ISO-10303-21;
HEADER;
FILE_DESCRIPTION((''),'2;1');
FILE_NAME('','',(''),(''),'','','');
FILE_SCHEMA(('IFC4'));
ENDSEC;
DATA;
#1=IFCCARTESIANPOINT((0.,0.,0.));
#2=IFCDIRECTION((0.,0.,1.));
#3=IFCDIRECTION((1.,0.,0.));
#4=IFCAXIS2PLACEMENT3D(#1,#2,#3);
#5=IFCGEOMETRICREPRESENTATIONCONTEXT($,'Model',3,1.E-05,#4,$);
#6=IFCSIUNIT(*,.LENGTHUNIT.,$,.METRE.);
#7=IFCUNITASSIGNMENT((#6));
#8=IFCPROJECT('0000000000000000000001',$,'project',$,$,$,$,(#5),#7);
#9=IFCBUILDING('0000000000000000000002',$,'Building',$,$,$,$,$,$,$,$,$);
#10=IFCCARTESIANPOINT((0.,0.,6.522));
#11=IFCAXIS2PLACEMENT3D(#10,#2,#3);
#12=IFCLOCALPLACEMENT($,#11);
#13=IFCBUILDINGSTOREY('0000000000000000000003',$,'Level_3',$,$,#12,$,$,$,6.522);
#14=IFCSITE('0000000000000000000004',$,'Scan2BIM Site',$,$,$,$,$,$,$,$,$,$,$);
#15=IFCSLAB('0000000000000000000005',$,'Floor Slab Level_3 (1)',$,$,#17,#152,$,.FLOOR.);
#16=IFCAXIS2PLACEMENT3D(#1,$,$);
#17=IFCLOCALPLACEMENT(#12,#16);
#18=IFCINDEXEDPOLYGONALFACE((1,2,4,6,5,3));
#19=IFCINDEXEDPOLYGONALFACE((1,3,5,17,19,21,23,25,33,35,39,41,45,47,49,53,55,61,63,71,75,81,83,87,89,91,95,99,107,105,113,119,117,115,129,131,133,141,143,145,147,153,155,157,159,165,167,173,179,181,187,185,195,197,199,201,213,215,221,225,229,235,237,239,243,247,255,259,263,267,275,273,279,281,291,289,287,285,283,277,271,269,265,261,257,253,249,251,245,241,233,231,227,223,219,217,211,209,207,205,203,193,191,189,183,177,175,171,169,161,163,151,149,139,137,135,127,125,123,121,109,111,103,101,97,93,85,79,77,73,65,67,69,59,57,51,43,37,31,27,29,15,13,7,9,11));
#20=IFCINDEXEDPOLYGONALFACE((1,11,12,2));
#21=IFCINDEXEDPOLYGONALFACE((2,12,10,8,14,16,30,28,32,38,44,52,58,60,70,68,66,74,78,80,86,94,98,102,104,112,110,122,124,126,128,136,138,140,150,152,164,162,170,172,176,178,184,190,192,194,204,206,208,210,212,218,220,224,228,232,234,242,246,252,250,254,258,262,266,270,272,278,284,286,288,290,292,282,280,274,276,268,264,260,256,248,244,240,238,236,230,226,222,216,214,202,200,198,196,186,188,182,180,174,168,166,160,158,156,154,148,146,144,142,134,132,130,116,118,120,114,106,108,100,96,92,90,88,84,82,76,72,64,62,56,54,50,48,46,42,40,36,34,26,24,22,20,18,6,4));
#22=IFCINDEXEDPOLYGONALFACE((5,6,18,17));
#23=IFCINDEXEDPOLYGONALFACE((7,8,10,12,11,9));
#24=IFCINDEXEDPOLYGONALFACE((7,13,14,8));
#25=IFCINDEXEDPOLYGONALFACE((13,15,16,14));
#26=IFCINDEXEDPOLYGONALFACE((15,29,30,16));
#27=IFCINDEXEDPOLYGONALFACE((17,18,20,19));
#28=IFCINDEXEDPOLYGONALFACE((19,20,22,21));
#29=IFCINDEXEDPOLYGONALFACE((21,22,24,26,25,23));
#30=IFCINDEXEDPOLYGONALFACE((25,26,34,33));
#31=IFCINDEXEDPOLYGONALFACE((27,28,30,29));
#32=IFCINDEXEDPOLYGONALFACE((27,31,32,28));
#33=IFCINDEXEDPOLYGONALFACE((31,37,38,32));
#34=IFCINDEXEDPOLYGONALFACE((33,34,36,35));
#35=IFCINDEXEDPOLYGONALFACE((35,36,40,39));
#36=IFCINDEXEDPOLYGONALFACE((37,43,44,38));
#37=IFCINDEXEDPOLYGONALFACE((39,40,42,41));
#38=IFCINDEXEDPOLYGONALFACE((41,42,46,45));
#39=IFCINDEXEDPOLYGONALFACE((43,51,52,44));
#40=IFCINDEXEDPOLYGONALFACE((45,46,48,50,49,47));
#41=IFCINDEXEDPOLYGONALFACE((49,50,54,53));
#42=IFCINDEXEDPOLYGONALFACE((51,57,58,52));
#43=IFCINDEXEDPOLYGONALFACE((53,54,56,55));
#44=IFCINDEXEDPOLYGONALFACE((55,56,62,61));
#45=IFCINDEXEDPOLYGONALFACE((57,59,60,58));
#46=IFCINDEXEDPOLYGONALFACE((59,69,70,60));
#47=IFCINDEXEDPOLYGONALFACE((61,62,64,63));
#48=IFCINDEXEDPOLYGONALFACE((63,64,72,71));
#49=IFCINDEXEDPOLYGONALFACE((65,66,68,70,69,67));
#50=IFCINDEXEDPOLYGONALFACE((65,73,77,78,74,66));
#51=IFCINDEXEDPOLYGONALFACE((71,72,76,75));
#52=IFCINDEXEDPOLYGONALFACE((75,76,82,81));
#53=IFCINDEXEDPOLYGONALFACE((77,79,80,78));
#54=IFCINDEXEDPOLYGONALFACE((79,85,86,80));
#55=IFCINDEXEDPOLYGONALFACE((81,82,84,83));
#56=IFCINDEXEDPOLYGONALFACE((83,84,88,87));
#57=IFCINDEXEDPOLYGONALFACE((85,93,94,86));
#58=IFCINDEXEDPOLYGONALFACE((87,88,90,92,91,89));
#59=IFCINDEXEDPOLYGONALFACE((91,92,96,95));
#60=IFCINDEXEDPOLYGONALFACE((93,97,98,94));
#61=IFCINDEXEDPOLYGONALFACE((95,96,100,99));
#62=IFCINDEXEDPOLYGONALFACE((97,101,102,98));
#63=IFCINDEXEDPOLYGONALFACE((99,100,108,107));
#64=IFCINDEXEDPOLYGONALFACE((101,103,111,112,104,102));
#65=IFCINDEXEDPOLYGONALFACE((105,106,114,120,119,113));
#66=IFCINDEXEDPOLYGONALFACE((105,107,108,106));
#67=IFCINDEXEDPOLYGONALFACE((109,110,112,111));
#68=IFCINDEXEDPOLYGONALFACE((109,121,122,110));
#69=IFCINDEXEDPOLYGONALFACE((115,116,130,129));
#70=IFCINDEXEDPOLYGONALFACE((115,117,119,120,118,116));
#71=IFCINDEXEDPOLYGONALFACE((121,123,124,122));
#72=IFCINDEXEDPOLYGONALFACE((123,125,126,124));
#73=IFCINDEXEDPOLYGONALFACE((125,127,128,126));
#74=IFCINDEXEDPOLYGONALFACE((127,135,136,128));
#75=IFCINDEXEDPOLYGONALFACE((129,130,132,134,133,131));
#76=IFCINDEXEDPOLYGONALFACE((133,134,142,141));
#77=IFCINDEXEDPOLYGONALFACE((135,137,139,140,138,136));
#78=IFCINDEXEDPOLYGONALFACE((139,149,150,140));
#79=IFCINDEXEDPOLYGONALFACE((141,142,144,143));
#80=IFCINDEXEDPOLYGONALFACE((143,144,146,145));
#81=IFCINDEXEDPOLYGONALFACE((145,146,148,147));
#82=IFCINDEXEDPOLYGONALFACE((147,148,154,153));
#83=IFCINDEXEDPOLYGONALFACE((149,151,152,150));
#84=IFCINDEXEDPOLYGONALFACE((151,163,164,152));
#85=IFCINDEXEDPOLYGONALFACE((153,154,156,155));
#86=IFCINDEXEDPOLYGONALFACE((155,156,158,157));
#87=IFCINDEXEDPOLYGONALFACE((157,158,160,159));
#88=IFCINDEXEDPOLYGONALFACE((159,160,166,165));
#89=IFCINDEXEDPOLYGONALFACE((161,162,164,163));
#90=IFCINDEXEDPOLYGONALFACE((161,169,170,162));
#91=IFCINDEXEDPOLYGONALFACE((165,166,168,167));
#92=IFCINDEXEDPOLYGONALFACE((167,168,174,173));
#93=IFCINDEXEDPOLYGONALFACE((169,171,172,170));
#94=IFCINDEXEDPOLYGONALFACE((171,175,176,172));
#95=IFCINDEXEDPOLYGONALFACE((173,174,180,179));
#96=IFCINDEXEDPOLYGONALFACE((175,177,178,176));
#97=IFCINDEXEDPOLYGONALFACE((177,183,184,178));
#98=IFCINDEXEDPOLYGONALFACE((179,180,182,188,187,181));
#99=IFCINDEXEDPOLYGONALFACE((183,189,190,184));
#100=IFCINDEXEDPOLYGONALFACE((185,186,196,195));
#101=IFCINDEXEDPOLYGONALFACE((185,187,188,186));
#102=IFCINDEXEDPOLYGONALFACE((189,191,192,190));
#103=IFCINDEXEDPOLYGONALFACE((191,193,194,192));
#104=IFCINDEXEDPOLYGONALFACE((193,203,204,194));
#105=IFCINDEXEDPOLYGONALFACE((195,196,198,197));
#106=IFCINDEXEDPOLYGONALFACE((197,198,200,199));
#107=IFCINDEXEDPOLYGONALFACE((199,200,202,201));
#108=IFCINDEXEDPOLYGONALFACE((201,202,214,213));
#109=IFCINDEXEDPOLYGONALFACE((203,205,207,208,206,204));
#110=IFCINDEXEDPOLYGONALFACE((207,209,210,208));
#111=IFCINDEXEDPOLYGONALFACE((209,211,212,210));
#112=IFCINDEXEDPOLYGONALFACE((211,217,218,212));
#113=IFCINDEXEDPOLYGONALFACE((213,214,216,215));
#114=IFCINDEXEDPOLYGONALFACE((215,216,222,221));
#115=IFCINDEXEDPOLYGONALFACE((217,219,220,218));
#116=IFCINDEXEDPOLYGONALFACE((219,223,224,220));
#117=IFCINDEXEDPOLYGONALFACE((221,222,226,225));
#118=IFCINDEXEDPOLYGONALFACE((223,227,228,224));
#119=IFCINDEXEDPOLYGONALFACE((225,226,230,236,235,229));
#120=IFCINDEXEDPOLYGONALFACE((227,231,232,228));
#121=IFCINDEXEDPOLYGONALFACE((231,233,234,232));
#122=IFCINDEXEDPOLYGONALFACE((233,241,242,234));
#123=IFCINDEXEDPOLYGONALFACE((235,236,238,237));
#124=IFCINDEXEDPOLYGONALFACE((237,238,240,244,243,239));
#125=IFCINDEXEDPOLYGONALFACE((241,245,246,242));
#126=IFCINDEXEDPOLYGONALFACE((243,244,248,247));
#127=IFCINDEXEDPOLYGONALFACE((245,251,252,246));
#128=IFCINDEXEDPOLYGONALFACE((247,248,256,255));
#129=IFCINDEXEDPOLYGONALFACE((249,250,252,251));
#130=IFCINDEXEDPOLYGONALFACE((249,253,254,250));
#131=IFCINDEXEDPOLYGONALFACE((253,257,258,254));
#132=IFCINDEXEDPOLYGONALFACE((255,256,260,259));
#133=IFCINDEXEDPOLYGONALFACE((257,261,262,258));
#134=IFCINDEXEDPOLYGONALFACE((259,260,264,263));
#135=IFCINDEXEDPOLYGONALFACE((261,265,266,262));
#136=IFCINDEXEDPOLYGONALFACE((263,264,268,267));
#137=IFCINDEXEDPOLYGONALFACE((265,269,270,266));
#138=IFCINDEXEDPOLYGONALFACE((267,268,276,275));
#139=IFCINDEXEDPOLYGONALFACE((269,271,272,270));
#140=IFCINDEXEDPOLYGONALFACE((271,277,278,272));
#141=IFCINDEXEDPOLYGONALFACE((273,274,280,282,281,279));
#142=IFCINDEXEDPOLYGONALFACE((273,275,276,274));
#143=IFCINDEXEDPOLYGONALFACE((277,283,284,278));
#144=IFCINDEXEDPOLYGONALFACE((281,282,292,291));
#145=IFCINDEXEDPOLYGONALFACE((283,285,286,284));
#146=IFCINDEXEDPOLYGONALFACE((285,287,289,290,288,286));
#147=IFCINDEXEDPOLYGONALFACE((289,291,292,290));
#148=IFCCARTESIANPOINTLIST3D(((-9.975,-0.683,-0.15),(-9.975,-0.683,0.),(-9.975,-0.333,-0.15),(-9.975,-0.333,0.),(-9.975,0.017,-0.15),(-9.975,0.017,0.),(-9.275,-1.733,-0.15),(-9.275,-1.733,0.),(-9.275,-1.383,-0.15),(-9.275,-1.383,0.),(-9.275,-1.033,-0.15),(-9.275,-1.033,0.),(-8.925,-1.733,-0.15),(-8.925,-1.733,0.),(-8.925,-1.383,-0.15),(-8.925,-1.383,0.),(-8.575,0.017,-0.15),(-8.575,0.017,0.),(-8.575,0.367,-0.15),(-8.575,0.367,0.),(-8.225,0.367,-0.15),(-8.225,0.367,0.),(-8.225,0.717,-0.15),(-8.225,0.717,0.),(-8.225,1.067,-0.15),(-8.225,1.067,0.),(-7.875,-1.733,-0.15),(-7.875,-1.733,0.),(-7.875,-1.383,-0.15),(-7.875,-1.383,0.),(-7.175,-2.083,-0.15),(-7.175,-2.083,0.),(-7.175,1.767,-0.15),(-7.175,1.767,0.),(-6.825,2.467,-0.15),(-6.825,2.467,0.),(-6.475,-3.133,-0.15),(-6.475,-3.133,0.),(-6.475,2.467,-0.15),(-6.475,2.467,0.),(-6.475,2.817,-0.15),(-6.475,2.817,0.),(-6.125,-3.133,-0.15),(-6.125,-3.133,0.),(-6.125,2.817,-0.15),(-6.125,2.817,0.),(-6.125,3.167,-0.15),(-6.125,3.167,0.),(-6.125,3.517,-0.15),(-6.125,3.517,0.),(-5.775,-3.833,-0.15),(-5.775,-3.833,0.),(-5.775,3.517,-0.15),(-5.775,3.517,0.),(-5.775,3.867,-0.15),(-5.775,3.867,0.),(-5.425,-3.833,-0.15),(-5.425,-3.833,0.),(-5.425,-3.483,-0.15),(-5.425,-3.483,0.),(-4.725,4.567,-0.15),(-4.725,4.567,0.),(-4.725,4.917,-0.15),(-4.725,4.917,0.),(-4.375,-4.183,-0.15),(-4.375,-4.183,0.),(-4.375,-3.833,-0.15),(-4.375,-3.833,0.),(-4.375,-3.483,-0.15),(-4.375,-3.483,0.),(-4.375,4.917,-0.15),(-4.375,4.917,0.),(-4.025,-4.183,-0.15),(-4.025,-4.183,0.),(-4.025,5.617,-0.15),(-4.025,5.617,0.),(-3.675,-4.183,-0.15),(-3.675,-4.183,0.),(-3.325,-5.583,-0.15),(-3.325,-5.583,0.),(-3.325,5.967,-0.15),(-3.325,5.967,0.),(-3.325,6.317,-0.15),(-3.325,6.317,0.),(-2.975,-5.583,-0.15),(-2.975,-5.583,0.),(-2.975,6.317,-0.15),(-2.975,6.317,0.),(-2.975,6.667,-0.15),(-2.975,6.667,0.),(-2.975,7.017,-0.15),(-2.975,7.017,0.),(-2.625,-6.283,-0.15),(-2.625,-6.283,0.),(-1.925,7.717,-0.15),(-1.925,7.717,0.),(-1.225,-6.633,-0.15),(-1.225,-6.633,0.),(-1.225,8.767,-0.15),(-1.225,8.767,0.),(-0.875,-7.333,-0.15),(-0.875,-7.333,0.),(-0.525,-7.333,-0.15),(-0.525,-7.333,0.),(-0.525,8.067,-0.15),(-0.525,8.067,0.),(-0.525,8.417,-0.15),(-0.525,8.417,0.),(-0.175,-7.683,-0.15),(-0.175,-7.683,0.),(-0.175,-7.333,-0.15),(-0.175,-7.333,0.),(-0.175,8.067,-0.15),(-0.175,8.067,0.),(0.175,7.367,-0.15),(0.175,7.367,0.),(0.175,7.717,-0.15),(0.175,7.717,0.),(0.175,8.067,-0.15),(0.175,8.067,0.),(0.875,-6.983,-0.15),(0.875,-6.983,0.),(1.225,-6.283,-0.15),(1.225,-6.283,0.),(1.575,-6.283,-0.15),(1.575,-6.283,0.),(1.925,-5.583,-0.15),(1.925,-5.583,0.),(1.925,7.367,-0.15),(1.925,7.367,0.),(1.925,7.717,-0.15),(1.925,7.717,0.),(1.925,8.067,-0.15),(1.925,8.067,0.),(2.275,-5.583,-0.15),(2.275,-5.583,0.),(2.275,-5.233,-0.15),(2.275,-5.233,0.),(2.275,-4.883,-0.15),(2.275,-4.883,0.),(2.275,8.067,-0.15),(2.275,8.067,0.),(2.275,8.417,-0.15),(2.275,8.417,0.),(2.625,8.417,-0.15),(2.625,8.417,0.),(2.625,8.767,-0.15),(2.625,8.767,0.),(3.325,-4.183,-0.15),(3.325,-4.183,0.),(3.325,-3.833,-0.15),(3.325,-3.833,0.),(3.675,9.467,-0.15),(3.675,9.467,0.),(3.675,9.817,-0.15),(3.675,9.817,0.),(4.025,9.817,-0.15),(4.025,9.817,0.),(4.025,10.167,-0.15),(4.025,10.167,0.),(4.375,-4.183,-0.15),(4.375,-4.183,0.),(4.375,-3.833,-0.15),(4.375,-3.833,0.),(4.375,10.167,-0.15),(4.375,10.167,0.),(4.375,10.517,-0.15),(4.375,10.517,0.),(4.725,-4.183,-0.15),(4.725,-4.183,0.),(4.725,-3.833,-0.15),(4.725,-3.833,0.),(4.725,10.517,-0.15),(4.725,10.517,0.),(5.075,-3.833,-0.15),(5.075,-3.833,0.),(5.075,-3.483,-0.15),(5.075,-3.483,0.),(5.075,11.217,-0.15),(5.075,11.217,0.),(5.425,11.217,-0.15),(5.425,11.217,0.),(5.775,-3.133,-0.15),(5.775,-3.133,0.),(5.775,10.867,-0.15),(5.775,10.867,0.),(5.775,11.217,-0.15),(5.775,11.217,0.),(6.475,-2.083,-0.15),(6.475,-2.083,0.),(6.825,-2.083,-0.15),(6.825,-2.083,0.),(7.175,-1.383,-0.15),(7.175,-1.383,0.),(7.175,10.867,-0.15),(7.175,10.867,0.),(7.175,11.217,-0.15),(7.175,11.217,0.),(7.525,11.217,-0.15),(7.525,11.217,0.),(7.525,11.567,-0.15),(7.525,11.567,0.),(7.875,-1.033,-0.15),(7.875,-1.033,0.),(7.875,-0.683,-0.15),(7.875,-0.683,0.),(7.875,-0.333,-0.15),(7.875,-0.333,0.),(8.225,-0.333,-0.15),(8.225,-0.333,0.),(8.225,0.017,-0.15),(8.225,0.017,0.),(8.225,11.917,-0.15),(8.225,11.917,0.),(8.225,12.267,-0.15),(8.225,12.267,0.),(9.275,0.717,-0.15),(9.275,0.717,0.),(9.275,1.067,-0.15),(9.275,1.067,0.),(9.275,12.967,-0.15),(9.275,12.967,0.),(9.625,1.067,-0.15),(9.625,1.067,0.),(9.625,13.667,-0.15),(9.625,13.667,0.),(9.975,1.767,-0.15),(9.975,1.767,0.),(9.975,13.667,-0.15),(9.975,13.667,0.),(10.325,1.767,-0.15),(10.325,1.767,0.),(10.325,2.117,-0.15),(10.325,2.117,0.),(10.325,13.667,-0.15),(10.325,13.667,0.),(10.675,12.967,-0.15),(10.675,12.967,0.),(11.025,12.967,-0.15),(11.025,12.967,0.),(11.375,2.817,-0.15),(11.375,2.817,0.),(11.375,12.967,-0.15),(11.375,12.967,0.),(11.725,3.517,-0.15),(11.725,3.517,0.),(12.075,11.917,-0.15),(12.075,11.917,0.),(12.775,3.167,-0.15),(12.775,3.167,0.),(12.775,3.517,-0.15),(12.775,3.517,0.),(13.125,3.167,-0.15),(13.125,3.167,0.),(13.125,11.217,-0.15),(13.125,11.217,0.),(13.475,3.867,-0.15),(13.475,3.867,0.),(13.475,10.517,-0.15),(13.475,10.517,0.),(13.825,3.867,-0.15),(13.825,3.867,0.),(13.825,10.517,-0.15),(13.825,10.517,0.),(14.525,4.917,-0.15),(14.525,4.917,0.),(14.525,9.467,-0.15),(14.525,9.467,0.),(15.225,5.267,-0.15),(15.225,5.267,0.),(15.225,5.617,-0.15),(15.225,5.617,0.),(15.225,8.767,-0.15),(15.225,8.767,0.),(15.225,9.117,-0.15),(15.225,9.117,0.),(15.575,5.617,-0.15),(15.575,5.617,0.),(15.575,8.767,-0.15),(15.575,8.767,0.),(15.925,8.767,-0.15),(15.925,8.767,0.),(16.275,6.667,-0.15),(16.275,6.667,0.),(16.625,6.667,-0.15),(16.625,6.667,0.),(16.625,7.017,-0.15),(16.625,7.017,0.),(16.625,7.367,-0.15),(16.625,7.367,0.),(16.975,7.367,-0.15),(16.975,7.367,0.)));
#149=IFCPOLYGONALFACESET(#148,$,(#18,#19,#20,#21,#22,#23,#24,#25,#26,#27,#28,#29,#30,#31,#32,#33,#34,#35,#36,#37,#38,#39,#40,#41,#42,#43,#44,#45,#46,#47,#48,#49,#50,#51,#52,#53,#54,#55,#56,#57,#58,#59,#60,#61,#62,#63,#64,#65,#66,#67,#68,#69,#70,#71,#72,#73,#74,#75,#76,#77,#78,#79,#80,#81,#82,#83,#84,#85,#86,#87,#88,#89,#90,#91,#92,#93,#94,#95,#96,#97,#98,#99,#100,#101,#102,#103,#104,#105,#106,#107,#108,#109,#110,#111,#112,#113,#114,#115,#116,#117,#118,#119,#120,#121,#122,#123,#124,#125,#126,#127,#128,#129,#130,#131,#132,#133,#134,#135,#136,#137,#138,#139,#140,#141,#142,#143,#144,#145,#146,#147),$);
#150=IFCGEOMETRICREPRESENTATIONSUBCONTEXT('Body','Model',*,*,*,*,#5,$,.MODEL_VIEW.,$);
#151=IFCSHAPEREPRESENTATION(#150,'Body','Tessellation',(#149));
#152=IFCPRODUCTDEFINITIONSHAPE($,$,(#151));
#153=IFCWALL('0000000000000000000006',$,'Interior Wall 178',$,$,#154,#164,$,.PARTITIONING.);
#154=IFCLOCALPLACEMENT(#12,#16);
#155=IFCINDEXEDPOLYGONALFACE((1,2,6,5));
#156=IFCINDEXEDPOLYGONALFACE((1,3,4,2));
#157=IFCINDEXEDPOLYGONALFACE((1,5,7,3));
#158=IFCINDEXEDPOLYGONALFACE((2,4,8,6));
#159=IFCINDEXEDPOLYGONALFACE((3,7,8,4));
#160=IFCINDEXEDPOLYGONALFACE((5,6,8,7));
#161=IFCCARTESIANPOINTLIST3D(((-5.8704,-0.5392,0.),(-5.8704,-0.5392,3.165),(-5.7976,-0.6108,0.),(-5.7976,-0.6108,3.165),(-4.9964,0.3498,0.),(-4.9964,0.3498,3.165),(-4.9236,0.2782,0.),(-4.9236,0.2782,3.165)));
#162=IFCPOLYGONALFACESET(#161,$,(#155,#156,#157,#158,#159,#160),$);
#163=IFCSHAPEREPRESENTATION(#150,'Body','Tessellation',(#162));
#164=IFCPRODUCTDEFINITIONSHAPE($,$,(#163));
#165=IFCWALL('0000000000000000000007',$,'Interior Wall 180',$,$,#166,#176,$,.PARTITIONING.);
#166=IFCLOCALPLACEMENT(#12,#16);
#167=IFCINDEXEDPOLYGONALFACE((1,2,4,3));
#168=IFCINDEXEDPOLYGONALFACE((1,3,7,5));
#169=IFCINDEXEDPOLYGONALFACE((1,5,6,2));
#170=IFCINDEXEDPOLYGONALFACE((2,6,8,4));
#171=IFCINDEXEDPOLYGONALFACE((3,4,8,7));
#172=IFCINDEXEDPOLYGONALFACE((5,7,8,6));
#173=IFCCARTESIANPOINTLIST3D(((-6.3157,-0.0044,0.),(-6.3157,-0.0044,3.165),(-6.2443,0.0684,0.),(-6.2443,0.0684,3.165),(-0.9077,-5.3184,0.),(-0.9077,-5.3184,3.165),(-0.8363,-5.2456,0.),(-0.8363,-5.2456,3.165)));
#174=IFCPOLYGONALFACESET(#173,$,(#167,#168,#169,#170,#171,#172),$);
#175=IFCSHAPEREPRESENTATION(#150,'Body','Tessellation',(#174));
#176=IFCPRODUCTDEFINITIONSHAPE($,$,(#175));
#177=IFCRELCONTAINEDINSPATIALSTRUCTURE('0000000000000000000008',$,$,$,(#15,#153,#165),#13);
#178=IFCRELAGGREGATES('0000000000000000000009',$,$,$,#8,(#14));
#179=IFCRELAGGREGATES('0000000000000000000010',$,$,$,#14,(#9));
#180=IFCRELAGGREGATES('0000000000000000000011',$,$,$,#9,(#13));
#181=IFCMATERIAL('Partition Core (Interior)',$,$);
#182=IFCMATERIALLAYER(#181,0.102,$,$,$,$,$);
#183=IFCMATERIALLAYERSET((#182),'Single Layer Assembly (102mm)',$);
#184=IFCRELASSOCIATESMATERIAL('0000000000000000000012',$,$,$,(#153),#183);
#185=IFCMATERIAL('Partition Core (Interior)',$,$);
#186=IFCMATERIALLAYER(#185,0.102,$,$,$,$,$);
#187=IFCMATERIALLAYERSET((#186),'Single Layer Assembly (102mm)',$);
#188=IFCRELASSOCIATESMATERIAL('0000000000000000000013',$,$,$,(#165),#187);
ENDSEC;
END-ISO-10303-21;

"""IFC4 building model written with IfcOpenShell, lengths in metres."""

from ifc_helpers import new_model, si_unit, frame, origin, origin_with_axes, place, context, subcontext, project, spatial, polyline, rectangle, outline, extrude, material, layer, layer_set, element, save


model = new_model("IFC4")

# Units and contexts
model_context = context("Model", 3, precision=1e-05, world=origin_with_axes())
body_context = subcontext(model_context, "Body", "Model", "MODEL_VIEW")
ifc_project = project(units=[si_unit("LENGTHUNIT", "METRE")], contexts=[model_context])

# Site, building, storey
site = spatial("IfcSite", under=ifc_project, Name="Scan2BIM Site")
building = spatial("IfcBuilding", under=site, Name="Building")
storey_placement = place(None, frame((0.0, 0.0, 6.522), z_axis=(0.0, 0.0, 1.0), x_axis=(1.0, 0.0, 0.0)))
storey = spatial("IfcBuildingStorey", under=building, at=storey_placement, Name="Level_3", Elevation=6.522)

# Slab
slab_placement = place(storey_placement, frame((0.0, 0.0, -0.15), z_axis=(0.0, 0.0, 1.0), x_axis=(1.0, 0.0, 0.0)))
element("IfcSlab", 1, at=slab_placement, inside=storey, Name="Floor Slab Level_3 (1)", PredefinedType="FLOOR", context=body_context, shape_type="SweptSolid", body=[
    extrude(outline(polyline([(-0.175, -7.683), (0.875, -6.983), (1.225, -6.283), (1.575, -6.283), (1.925, -5.583), (2.275, -5.583), (2.275, -5.233), (2.275, -4.883), (3.325, -4.183), (3.325, -3.833), (4.375, -3.833), (4.375, -4.183), (4.725, -4.183), (4.725, -3.833), (5.075, -3.833), (5.075, -3.483), (5.775, -3.133), (6.475, -2.083), (6.825, -2.083), (7.175, -1.383), (7.875, -1.033), (7.875, -0.683), (7.875, -0.333), (8.225, -0.333), (8.225, 0.017), (9.275, 0.717), (9.275, 1.067), (9.625, 1.067), (9.975, 1.767), (10.325, 1.767), (10.325, 2.117), (11.375, 2.817), (11.725, 3.517), (12.775, 3.517), (12.775, 3.167), (13.125, 3.167), (13.475, 3.867), (13.825, 3.867), (14.525, 4.917), (15.225, 5.267), (15.225, 5.617), (15.575, 5.617), (16.275, 6.667), (16.625, 6.667), (16.625, 7.017), (16.625, 7.367), (16.975, 7.367), (15.925, 8.767), (15.575, 8.767), (15.225, 8.767), (15.225, 9.117), (14.525, 9.467), (13.825, 10.517), (13.475, 10.517), (13.125, 11.217), (12.075, 11.917), (11.375, 12.967), (11.025, 12.967), (10.675, 12.967), (10.325, 13.667), (9.975, 13.667), (9.625, 13.667), (9.275, 12.967), (8.225, 12.267), (8.225, 11.917), (7.525, 11.567), (7.525, 11.217), (7.175, 11.217), (7.175, 10.867), (5.775, 10.867), (5.775, 11.217), (5.425, 11.217), (5.075, 11.217), (4.725, 10.517), (4.375, 10.517), (4.375, 10.167), (4.025, 10.167), (4.025, 9.817), (3.675, 9.817), (3.675, 9.467), (2.625, 8.767), (2.625, 8.417), (2.275, 8.417), (2.275, 8.067), (1.925, 8.067), (1.925, 7.717), (1.925, 7.367), (0.175, 7.367), (0.175, 7.717), (0.175, 8.067), (-0.175, 8.067), (-0.525, 8.067), (-0.525, 8.417), (-1.225, 8.767), (-1.925, 7.717), (-2.975, 7.017), (-2.975, 6.667), (-2.975, 6.317), (-3.325, 6.317), (-3.325, 5.967), (-4.025, 5.617), (-4.375, 4.917), (-4.725, 4.917), (-4.725, 4.567), (-5.775, 3.867), (-5.775, 3.517), (-6.125, 3.517), (-6.125, 3.167), (-6.125, 2.817), (-6.475, 2.817), (-6.475, 2.467), (-6.825, 2.467), (-7.175, 1.767), (-8.225, 1.067), (-8.225, 0.717), (-8.225, 0.367), (-8.575, 0.367), (-8.575, 0.017), (-9.975, 0.017), (-9.975, -0.333), (-9.975, -0.683), (-9.275, -1.033), (-9.275, -1.383), (-9.275, -1.733), (-8.925, -1.733), (-8.925, -1.383), (-7.875, -1.383), (-7.875, -1.733), (-7.175, -2.083), (-6.475, -3.133), (-6.125, -3.133), (-5.775, -3.833), (-5.425, -3.833), (-5.425, -3.483), (-4.375, -3.483), (-4.375, -3.833), (-4.375, -4.183), (-4.025, -4.183), (-3.675, -4.183), (-3.325, -5.583), (-2.975, -5.583), (-2.625, -6.283), (-1.225, -6.633), (-0.875, -7.333), (-0.525, -7.333), (-0.175, -7.333), (-0.175, -7.683)])), origin(), (0.0, 0.0, 1.0), 0.15),
])

# Walls
ifc_material_1 = material(Name="Partition Core (Interior)")
ifc_layer_1 = layer(ifc_material_1, 0.102)
ifc_layer_set_1 = layer_set([ifc_layer_1], Name="Single Layer Assembly (102mm)")
wall_1_placement = place(storey_placement, frame((-5.397, -0.1305, 0.0), z_axis=(0.0, 0.0, 1.0), x_axis=(-0.701065, -0.713097, 0.0)))
element("IfcWall", 2, at=wall_1_placement, inside=storey, material=ifc_layer_set_1, Name="Interior Wall 178", PredefinedType="PARTITIONING", context=body_context, shape_type="SweptSolid", body=[
    extrude(rectangle(XDim=1.2467, YDim=0.102), origin(), (0.0, 0.0, 1.0), 3.165),
])
ifc_material_2 = material(Name="Partition Core (Interior)")
ifc_layer_2 = layer(ifc_material_2, 0.102)
ifc_layer_set_2 = layer_set([ifc_layer_2], Name="Single Layer Assembly (102mm)")
wall_2_placement = place(storey_placement, frame((-3.576, -2.625, 0.0), z_axis=(0.0, 0.0, 1.0), x_axis=(-0.713279, 0.700881, 0.0)))
element("IfcWall", 3, at=wall_2_placement, inside=storey, material=ifc_layer_set_2, Name="Interior Wall 180", PredefinedType="PARTITIONING", context=body_context, shape_type="SweptSolid", body=[
    extrude(rectangle(XDim=7.5819, YDim=0.102), origin(), (0.0, 0.0, 1.0), 3.165),
])

save(model, "model.ifc")
